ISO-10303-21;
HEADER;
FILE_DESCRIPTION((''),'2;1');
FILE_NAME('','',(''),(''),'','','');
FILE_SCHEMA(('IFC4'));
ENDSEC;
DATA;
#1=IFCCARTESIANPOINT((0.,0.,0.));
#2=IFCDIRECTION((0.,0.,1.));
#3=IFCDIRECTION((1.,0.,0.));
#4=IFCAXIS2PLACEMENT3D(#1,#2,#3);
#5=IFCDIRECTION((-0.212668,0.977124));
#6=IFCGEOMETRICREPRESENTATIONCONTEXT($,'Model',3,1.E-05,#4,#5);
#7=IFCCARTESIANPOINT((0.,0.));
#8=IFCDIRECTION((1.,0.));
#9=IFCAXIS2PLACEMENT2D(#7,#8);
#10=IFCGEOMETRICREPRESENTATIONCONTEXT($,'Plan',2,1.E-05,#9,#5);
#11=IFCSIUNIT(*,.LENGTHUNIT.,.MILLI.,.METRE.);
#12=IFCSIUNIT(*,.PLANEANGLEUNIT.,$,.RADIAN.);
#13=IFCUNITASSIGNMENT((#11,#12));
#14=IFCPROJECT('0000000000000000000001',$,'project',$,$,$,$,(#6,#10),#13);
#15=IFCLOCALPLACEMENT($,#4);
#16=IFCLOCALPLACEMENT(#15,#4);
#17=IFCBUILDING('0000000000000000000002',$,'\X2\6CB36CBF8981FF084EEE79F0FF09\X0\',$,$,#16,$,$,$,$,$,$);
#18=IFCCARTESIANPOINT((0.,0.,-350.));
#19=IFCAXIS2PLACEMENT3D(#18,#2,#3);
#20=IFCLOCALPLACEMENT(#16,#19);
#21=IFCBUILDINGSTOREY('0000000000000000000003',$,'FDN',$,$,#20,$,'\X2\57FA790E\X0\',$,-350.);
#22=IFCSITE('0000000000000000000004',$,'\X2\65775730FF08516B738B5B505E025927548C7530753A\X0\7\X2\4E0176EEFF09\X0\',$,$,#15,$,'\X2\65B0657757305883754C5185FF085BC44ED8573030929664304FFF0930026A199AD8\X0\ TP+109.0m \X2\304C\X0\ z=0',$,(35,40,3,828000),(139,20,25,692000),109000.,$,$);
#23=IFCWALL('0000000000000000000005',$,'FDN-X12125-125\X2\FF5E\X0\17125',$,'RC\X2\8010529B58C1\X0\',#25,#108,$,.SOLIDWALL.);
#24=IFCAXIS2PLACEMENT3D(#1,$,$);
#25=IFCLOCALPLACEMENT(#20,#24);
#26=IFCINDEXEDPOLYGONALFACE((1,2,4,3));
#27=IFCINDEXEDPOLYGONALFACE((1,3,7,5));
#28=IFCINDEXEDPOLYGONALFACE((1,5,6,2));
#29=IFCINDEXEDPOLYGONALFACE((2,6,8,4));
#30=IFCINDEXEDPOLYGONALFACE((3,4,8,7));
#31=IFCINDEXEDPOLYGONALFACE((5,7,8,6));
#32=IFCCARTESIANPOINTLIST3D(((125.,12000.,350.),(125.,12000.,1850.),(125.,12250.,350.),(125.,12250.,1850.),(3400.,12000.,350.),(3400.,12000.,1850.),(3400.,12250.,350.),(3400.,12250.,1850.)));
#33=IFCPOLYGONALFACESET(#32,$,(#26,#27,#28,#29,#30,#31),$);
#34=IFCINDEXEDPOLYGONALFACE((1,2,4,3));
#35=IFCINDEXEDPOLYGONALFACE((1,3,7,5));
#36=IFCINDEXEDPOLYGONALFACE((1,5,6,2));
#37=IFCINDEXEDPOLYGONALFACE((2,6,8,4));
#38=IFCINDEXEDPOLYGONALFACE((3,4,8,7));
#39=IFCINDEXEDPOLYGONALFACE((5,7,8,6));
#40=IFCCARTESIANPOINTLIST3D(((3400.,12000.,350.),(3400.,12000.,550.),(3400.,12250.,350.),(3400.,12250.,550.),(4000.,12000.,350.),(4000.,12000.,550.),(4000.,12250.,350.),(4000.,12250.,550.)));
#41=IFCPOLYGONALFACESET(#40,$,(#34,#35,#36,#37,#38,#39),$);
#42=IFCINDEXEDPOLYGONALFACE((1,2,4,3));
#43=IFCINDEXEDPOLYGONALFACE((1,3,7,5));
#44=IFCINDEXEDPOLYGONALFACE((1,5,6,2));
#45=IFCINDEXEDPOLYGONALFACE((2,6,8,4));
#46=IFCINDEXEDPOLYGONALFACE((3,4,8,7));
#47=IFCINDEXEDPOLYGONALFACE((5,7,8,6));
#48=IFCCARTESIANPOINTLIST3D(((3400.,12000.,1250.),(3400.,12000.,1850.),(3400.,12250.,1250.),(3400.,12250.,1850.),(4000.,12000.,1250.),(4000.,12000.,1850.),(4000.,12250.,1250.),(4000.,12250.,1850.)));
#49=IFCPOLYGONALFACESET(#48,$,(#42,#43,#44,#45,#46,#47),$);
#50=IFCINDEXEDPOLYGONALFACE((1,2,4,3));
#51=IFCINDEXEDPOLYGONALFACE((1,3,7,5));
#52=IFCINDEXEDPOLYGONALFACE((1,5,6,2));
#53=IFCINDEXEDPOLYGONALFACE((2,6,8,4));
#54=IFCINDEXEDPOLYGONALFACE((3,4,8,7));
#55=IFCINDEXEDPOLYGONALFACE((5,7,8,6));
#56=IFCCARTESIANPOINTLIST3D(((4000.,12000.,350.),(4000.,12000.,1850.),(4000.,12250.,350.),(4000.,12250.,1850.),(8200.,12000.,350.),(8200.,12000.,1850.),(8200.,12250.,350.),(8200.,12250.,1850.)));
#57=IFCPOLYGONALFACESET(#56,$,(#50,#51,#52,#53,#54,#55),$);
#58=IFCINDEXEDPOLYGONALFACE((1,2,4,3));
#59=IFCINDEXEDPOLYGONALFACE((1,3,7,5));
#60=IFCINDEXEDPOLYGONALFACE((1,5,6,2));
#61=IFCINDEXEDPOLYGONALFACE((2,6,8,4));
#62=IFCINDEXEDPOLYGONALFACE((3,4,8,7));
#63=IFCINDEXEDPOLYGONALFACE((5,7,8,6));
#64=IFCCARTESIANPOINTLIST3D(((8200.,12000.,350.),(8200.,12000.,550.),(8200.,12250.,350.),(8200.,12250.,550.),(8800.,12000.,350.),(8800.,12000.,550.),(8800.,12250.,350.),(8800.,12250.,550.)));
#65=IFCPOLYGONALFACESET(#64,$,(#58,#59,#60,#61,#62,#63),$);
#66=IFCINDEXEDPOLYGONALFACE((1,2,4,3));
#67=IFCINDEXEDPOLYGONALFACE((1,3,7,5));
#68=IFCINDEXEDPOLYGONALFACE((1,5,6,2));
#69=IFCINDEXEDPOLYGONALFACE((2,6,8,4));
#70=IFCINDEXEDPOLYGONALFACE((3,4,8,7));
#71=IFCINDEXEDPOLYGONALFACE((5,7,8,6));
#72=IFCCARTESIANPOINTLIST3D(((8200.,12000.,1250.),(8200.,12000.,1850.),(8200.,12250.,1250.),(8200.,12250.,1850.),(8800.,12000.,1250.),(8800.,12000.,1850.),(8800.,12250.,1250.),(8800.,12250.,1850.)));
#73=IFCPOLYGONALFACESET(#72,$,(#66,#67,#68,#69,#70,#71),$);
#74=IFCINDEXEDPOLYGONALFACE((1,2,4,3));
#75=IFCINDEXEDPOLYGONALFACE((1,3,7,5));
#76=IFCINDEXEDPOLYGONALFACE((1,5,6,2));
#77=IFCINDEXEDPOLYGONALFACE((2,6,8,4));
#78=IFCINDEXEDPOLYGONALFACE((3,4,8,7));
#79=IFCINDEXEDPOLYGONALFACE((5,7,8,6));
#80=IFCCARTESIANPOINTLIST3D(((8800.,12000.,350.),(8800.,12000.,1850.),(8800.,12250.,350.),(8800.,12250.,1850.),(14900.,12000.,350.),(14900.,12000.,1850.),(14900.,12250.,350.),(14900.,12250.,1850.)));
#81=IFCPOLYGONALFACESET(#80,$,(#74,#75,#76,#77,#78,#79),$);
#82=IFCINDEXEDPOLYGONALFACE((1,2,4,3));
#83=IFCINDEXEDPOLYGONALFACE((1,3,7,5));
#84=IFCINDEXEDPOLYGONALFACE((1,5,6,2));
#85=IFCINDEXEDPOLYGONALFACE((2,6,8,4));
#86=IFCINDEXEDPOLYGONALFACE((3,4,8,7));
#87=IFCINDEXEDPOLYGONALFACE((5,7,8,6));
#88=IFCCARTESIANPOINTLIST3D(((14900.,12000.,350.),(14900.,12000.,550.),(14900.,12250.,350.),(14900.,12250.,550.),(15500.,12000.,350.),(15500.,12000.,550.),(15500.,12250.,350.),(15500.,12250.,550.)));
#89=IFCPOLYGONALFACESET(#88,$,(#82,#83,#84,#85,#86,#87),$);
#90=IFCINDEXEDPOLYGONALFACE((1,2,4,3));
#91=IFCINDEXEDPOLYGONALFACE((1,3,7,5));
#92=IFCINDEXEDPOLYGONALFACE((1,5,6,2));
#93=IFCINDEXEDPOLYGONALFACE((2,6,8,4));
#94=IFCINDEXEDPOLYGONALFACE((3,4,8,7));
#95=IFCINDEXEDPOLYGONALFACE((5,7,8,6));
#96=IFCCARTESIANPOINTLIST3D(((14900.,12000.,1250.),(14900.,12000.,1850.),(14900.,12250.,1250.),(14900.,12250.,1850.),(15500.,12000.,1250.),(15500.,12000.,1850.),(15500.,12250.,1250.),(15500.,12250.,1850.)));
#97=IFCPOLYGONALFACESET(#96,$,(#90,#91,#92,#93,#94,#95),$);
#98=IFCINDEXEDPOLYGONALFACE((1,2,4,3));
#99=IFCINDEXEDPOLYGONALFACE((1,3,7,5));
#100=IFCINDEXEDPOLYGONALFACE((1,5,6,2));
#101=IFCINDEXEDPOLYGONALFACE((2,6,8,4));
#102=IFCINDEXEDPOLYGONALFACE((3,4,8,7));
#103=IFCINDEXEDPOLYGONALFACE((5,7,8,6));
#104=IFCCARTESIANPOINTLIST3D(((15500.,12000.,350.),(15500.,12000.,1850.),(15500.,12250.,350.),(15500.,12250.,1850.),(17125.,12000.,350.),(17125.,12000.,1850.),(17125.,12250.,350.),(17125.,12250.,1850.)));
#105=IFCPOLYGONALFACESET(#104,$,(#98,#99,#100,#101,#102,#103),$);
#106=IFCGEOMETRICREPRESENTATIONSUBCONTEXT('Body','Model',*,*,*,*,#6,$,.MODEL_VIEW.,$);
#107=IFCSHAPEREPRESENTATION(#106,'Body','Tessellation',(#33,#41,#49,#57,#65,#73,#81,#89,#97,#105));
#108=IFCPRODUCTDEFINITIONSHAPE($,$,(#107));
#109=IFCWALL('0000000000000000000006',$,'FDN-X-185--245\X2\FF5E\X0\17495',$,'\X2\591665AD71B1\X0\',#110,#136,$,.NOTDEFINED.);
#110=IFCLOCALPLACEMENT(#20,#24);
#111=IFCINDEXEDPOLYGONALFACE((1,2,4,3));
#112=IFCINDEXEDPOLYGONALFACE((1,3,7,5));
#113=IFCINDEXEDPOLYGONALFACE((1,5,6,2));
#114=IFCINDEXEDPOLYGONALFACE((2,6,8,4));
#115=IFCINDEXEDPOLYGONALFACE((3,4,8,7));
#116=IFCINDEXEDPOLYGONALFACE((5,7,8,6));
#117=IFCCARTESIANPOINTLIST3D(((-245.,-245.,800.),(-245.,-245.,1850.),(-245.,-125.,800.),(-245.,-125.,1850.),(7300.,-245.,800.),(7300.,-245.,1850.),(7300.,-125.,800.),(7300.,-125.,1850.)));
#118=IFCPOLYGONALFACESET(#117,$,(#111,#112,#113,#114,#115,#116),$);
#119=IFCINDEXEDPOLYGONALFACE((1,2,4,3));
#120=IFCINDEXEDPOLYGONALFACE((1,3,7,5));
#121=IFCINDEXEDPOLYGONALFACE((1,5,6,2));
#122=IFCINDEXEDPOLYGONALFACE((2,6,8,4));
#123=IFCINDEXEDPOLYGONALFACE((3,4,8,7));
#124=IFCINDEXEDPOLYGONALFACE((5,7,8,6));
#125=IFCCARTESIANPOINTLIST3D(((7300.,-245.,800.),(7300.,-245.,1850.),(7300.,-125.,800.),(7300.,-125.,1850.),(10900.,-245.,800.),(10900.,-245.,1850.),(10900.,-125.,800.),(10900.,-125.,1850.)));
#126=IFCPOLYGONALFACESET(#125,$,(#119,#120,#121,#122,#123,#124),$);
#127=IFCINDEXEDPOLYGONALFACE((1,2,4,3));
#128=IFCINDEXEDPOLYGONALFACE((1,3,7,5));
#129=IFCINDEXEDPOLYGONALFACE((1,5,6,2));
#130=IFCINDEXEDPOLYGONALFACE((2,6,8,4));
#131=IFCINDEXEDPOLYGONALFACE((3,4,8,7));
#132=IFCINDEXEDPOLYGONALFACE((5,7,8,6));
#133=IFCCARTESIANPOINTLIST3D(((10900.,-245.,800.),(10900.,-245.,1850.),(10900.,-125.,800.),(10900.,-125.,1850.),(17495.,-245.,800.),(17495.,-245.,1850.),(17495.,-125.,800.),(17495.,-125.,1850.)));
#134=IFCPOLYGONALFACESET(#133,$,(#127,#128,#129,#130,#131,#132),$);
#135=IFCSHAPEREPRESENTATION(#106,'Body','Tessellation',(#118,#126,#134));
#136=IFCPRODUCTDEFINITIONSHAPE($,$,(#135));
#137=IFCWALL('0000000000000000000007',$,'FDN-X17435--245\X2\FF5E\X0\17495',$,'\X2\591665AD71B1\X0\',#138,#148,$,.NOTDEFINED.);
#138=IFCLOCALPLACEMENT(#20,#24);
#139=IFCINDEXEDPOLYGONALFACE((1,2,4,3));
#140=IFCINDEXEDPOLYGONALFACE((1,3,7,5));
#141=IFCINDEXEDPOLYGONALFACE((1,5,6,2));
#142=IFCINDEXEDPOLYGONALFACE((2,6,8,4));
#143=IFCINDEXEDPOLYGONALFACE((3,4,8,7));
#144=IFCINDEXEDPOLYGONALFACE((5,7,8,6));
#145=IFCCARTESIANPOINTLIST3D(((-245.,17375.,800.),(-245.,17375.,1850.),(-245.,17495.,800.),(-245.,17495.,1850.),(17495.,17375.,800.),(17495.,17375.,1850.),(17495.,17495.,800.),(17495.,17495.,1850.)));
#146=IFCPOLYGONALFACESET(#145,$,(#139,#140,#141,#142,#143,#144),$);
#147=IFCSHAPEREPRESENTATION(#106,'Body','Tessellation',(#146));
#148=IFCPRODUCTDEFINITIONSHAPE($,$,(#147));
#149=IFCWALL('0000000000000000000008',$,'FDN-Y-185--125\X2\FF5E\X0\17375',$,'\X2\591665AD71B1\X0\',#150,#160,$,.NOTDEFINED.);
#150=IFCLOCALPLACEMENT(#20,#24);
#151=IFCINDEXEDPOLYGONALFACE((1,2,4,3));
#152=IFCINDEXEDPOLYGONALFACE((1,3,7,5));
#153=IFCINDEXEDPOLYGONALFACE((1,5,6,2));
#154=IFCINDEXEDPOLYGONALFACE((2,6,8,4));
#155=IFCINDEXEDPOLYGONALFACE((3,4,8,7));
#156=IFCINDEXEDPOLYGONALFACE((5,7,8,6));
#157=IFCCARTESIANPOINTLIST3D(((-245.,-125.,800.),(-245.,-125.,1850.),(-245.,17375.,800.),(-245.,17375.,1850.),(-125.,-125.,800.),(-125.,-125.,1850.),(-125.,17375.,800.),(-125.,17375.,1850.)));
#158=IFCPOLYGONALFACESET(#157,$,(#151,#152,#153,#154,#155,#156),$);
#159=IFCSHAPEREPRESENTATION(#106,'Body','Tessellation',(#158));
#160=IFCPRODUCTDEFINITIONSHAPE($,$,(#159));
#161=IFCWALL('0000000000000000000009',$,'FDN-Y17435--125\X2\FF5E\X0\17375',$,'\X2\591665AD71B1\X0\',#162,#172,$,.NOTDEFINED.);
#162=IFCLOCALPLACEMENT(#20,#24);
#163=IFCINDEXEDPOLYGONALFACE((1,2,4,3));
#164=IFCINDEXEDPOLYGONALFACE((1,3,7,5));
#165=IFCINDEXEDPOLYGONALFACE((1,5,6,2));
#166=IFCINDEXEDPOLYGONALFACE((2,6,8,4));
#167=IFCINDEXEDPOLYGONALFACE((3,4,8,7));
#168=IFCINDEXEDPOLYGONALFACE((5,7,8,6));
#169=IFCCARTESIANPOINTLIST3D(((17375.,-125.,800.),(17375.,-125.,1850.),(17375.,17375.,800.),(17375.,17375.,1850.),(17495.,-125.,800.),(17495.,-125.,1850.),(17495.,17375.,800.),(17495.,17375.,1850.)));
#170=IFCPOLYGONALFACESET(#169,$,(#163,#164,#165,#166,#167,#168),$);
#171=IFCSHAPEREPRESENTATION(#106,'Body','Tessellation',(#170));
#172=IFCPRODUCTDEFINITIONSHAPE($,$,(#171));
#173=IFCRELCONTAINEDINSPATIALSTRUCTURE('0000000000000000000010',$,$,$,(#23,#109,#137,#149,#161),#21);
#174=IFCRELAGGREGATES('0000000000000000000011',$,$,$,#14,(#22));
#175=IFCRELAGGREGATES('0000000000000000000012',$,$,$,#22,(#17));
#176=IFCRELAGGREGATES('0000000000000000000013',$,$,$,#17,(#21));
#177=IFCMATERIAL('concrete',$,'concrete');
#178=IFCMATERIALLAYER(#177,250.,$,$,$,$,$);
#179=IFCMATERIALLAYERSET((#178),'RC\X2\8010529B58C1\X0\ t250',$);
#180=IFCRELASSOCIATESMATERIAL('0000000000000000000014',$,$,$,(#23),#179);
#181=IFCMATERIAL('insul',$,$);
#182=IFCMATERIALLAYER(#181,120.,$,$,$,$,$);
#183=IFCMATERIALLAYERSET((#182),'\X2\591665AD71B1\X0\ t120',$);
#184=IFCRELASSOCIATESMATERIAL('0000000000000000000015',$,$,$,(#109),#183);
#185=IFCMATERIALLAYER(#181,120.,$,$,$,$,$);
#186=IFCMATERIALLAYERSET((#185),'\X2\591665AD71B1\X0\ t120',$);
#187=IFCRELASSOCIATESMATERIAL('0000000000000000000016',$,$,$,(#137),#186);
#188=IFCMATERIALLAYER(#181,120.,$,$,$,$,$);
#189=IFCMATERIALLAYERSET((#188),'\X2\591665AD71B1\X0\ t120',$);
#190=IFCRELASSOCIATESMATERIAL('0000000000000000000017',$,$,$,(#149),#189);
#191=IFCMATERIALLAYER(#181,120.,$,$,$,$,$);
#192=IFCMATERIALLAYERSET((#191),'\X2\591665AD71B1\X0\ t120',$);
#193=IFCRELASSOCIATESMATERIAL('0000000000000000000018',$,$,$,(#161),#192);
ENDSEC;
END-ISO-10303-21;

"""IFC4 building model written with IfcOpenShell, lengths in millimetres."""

from ifc_helpers import new_model, si_unit, direction, frame, frame_2d, origin_with_axes, origin_2d_with_axis, place, context, subcontext, project, spatial, rectangle, extrude, material, layer, layer_set, layer_usage, element, save


model = new_model("IFC4")

# Units and contexts
model_context = context("Model", 3, precision=1e-05, world=origin_with_axes(), true_north=direction((-0.212668, 0.977124)))
plan_context = context("Plan", 2, precision=1e-05, world=origin_2d_with_axis(), true_north=direction((-0.212668, 0.977124)))
body_context = subcontext(model_context, "Body", "Model", "MODEL_VIEW")
ifc_project = project(units=[si_unit("LENGTHUNIT", "METRE", prefix="MILLI"), si_unit("PLANEANGLEUNIT", "RADIAN")], contexts=[model_context, plan_context])

# Site, building, storey
site_placement = place(None, origin_with_axes())
site = spatial("IfcSite", under=ifc_project, at=site_placement, Name="敷地（八王子市大和田町7丁目）", LongName="新敷地境界内（寄付地を除く）。標高 TP+109.0m が z=0", RefLatitude=(35, 40, 3, 828000), RefLongitude=(139, 20, 25, 692000), RefElevation=109000.0)
building_placement = place(site_placement, origin_with_axes())
building = spatial("IfcBuilding", under=site, at=building_placement, Name="河沿要（仮称）")
storey_placement = place(building_placement, frame((0.0, 0.0, -350.0), z_axis=(0.0, 0.0, 1.0), x_axis=(1.0, 0.0, 0.0)))
storey = spatial("IfcBuildingStorey", under=building, at=storey_placement, Name="FDN", LongName="基礎", Elevation=-350.0)

# Shared definitions
ifc_material_1 = material(Name="concrete", Category="concrete")

# Wall, openings
ifc_layer_1 = layer(ifc_material_1, 250.0)
ifc_layer_set_1 = layer_set([ifc_layer_1], Name="RC耐力壁 t250")
ifc_layer_usage_1 = layer_usage(ifc_layer_set_1, "AXIS2", "POSITIVE", 0.0)
wall_1_placement = place(storey_placement, origin_with_axes())
wall_1 = element("IfcWall", 1, at=wall_1_placement, inside=storey, material=ifc_layer_usage_1, Name="FDN-X12125-125～17125", ObjectType="RC耐力壁", PredefinedType="SOLIDWALL", context=body_context, shape_type="SweptSolid", body=[
    extrude(rectangle(XDim=3275.0, YDim=250.0, at=frame_2d((1762.5, 12125.0))), frame((0.0, 0.0, 350.0)), (0.0, 0.0, 1.0), 1500.0),
    extrude(rectangle(XDim=600.0, YDim=250.0, at=frame_2d((3700.0, 12125.0))), frame((0.0, 0.0, 350.0)), (0.0, 0.0, 1.0), 200.0),
    extrude(rectangle(XDim=600.0, YDim=250.0, at=frame_2d((3700.0, 12125.0))), frame((0.0, 0.0, 1250.0)), (0.0, 0.0, 1.0), 600.0),
    extrude(rectangle(XDim=4200.0, YDim=250.0, at=frame_2d((6100.0, 12125.0))), frame((0.0, 0.0, 350.0)), (0.0, 0.0, 1.0), 1500.0),
    extrude(rectangle(XDim=600.0, YDim=250.0, at=frame_2d((8500.0, 12125.0))), frame((0.0, 0.0, 350.0)), (0.0, 0.0, 1.0), 200.0),
    extrude(rectangle(XDim=600.0, YDim=250.0, at=frame_2d((8500.0, 12125.0))), frame((0.0, 0.0, 1250.0)), (0.0, 0.0, 1.0), 600.0),
    extrude(rectangle(XDim=6100.0, YDim=250.0, at=frame_2d((11850.0, 12125.0))), frame((0.0, 0.0, 350.0)), (0.0, 0.0, 1.0), 1500.0),
    extrude(rectangle(XDim=600.0, YDim=250.0, at=frame_2d((15200.0, 12125.0))), frame((0.0, 0.0, 350.0)), (0.0, 0.0, 1.0), 200.0),
    extrude(rectangle(XDim=600.0, YDim=250.0, at=frame_2d((15200.0, 12125.0))), frame((0.0, 0.0, 1250.0)), (0.0, 0.0, 1.0), 600.0),
    extrude(rectangle(XDim=1625.0, YDim=250.0, at=frame_2d((16312.5, 12125.0))), frame((0.0, 0.0, 350.0)), (0.0, 0.0, 1.0), 1500.0),
])
opening_1_placement = place(storey_placement, origin_with_axes())
element("IfcOpeningElement", 2, at=opening_1_placement, inside=storey, cuts=wall_1, PredefinedType="OPENING", context=body_context, shape_type="SweptSolid", body=[
    extrude(rectangle(XDim=600.0, YDim=300.0, at=frame_2d((3700.0, 12125.0))), frame((0.0, 0.0, 550.0)), (0.0, 0.0, 1.0), 700.0),
])
opening_2_placement = place(storey_placement, origin_with_axes())
element("IfcOpeningElement", 3, at=opening_2_placement, inside=storey, cuts=wall_1, PredefinedType="OPENING", context=body_context, shape_type="SweptSolid", body=[
    extrude(rectangle(XDim=600.0, YDim=300.0, at=frame_2d((8500.0, 12125.0))), frame((0.0, 0.0, 550.0)), (0.0, 0.0, 1.0), 700.0),
])
opening_3_placement = place(storey_placement, origin_with_axes())
element("IfcOpeningElement", 4, at=opening_3_placement, inside=storey, cuts=wall_1, PredefinedType="OPENING", context=body_context, shape_type="SweptSolid", body=[
    extrude(rectangle(XDim=600.0, YDim=300.0, at=frame_2d((15200.0, 12125.0))), frame((0.0, 0.0, 550.0)), (0.0, 0.0, 1.0), 700.0),
])

# Walls
ifc_material_2 = material(Name="insul")
ifc_layer_2 = layer(ifc_material_2, 120.0)
ifc_layer_set_2 = layer_set([ifc_layer_2], Name="外断熱 t120")
ifc_layer_usage_2 = layer_usage(ifc_layer_set_2, "AXIS2", "POSITIVE", 0.0)
wall_2_placement = place(storey_placement, origin_with_axes())
element("IfcWall", 5, at=wall_2_placement, inside=storey, material=ifc_layer_usage_2, Name="FDN-X-185--245～17495", ObjectType="外断熱", PredefinedType="NOTDEFINED", context=body_context, shape_type="SweptSolid", body=[
    extrude(rectangle(XDim=7545.0, YDim=120.0, at=frame_2d((3527.5, -185.0))), frame((0.0, 0.0, 800.0)), (0.0, 0.0, 1.0), 1050.0),
    extrude(rectangle(XDim=3600.0, YDim=120.0, at=frame_2d((9100.0, -185.0))), frame((0.0, 0.0, 800.0)), (0.0, 0.0, 1.0), 1050.0),
    extrude(rectangle(XDim=6595.0, YDim=120.0, at=frame_2d((14197.5, -185.0))), frame((0.0, 0.0, 800.0)), (0.0, 0.0, 1.0), 1050.0),
])
ifc_layer_3 = layer(ifc_material_2, 120.0)
ifc_layer_set_3 = layer_set([ifc_layer_3], Name="外断熱 t120")
ifc_layer_usage_3 = layer_usage(ifc_layer_set_3, "AXIS2", "POSITIVE", 0.0)
wall_3_placement = place(storey_placement, origin_with_axes())
element("IfcWall", 6, at=wall_3_placement, inside=storey, material=ifc_layer_usage_3, Name="FDN-X17435--245～17495", ObjectType="外断熱", PredefinedType="NOTDEFINED", context=body_context, shape_type="SweptSolid", body=[
    extrude(rectangle(XDim=17740.0, YDim=120.0, at=frame_2d((8625.0, 17435.0))), frame((0.0, 0.0, 800.0)), (0.0, 0.0, 1.0), 1050.0),
])
ifc_layer_4 = layer(ifc_material_2, 120.0)
ifc_layer_set_4 = layer_set([ifc_layer_4], Name="外断熱 t120")
ifc_layer_usage_4 = layer_usage(ifc_layer_set_4, "AXIS2", "POSITIVE", 0.0)
wall_4_placement = place(storey_placement, origin_with_axes())
element("IfcWall", 7, at=wall_4_placement, inside=storey, material=ifc_layer_usage_4, Name="FDN-Y-185--125～17375", ObjectType="外断熱", PredefinedType="NOTDEFINED", context=body_context, shape_type="SweptSolid", body=[
    extrude(rectangle(XDim=120.0, YDim=17500.0, at=frame_2d((-185.0, 8625.0))), frame((0.0, 0.0, 800.0)), (0.0, 0.0, 1.0), 1050.0),
])
ifc_layer_5 = layer(ifc_material_2, 120.0)
ifc_layer_set_5 = layer_set([ifc_layer_5], Name="外断熱 t120")
ifc_layer_usage_5 = layer_usage(ifc_layer_set_5, "AXIS2", "POSITIVE", 0.0)
wall_5_placement = place(storey_placement, origin_with_axes())
element("IfcWall", 8, at=wall_5_placement, inside=storey, material=ifc_layer_usage_5, Name="FDN-Y17435--125～17375", ObjectType="外断熱", PredefinedType="NOTDEFINED", context=body_context, shape_type="SweptSolid", body=[
    extrude(rectangle(XDim=120.0, YDim=17500.0, at=frame_2d((17435.0, 8625.0))), frame((0.0, 0.0, 800.0)), (0.0, 0.0, 1.0), 1050.0),
])

save(model, "model.ifc")
